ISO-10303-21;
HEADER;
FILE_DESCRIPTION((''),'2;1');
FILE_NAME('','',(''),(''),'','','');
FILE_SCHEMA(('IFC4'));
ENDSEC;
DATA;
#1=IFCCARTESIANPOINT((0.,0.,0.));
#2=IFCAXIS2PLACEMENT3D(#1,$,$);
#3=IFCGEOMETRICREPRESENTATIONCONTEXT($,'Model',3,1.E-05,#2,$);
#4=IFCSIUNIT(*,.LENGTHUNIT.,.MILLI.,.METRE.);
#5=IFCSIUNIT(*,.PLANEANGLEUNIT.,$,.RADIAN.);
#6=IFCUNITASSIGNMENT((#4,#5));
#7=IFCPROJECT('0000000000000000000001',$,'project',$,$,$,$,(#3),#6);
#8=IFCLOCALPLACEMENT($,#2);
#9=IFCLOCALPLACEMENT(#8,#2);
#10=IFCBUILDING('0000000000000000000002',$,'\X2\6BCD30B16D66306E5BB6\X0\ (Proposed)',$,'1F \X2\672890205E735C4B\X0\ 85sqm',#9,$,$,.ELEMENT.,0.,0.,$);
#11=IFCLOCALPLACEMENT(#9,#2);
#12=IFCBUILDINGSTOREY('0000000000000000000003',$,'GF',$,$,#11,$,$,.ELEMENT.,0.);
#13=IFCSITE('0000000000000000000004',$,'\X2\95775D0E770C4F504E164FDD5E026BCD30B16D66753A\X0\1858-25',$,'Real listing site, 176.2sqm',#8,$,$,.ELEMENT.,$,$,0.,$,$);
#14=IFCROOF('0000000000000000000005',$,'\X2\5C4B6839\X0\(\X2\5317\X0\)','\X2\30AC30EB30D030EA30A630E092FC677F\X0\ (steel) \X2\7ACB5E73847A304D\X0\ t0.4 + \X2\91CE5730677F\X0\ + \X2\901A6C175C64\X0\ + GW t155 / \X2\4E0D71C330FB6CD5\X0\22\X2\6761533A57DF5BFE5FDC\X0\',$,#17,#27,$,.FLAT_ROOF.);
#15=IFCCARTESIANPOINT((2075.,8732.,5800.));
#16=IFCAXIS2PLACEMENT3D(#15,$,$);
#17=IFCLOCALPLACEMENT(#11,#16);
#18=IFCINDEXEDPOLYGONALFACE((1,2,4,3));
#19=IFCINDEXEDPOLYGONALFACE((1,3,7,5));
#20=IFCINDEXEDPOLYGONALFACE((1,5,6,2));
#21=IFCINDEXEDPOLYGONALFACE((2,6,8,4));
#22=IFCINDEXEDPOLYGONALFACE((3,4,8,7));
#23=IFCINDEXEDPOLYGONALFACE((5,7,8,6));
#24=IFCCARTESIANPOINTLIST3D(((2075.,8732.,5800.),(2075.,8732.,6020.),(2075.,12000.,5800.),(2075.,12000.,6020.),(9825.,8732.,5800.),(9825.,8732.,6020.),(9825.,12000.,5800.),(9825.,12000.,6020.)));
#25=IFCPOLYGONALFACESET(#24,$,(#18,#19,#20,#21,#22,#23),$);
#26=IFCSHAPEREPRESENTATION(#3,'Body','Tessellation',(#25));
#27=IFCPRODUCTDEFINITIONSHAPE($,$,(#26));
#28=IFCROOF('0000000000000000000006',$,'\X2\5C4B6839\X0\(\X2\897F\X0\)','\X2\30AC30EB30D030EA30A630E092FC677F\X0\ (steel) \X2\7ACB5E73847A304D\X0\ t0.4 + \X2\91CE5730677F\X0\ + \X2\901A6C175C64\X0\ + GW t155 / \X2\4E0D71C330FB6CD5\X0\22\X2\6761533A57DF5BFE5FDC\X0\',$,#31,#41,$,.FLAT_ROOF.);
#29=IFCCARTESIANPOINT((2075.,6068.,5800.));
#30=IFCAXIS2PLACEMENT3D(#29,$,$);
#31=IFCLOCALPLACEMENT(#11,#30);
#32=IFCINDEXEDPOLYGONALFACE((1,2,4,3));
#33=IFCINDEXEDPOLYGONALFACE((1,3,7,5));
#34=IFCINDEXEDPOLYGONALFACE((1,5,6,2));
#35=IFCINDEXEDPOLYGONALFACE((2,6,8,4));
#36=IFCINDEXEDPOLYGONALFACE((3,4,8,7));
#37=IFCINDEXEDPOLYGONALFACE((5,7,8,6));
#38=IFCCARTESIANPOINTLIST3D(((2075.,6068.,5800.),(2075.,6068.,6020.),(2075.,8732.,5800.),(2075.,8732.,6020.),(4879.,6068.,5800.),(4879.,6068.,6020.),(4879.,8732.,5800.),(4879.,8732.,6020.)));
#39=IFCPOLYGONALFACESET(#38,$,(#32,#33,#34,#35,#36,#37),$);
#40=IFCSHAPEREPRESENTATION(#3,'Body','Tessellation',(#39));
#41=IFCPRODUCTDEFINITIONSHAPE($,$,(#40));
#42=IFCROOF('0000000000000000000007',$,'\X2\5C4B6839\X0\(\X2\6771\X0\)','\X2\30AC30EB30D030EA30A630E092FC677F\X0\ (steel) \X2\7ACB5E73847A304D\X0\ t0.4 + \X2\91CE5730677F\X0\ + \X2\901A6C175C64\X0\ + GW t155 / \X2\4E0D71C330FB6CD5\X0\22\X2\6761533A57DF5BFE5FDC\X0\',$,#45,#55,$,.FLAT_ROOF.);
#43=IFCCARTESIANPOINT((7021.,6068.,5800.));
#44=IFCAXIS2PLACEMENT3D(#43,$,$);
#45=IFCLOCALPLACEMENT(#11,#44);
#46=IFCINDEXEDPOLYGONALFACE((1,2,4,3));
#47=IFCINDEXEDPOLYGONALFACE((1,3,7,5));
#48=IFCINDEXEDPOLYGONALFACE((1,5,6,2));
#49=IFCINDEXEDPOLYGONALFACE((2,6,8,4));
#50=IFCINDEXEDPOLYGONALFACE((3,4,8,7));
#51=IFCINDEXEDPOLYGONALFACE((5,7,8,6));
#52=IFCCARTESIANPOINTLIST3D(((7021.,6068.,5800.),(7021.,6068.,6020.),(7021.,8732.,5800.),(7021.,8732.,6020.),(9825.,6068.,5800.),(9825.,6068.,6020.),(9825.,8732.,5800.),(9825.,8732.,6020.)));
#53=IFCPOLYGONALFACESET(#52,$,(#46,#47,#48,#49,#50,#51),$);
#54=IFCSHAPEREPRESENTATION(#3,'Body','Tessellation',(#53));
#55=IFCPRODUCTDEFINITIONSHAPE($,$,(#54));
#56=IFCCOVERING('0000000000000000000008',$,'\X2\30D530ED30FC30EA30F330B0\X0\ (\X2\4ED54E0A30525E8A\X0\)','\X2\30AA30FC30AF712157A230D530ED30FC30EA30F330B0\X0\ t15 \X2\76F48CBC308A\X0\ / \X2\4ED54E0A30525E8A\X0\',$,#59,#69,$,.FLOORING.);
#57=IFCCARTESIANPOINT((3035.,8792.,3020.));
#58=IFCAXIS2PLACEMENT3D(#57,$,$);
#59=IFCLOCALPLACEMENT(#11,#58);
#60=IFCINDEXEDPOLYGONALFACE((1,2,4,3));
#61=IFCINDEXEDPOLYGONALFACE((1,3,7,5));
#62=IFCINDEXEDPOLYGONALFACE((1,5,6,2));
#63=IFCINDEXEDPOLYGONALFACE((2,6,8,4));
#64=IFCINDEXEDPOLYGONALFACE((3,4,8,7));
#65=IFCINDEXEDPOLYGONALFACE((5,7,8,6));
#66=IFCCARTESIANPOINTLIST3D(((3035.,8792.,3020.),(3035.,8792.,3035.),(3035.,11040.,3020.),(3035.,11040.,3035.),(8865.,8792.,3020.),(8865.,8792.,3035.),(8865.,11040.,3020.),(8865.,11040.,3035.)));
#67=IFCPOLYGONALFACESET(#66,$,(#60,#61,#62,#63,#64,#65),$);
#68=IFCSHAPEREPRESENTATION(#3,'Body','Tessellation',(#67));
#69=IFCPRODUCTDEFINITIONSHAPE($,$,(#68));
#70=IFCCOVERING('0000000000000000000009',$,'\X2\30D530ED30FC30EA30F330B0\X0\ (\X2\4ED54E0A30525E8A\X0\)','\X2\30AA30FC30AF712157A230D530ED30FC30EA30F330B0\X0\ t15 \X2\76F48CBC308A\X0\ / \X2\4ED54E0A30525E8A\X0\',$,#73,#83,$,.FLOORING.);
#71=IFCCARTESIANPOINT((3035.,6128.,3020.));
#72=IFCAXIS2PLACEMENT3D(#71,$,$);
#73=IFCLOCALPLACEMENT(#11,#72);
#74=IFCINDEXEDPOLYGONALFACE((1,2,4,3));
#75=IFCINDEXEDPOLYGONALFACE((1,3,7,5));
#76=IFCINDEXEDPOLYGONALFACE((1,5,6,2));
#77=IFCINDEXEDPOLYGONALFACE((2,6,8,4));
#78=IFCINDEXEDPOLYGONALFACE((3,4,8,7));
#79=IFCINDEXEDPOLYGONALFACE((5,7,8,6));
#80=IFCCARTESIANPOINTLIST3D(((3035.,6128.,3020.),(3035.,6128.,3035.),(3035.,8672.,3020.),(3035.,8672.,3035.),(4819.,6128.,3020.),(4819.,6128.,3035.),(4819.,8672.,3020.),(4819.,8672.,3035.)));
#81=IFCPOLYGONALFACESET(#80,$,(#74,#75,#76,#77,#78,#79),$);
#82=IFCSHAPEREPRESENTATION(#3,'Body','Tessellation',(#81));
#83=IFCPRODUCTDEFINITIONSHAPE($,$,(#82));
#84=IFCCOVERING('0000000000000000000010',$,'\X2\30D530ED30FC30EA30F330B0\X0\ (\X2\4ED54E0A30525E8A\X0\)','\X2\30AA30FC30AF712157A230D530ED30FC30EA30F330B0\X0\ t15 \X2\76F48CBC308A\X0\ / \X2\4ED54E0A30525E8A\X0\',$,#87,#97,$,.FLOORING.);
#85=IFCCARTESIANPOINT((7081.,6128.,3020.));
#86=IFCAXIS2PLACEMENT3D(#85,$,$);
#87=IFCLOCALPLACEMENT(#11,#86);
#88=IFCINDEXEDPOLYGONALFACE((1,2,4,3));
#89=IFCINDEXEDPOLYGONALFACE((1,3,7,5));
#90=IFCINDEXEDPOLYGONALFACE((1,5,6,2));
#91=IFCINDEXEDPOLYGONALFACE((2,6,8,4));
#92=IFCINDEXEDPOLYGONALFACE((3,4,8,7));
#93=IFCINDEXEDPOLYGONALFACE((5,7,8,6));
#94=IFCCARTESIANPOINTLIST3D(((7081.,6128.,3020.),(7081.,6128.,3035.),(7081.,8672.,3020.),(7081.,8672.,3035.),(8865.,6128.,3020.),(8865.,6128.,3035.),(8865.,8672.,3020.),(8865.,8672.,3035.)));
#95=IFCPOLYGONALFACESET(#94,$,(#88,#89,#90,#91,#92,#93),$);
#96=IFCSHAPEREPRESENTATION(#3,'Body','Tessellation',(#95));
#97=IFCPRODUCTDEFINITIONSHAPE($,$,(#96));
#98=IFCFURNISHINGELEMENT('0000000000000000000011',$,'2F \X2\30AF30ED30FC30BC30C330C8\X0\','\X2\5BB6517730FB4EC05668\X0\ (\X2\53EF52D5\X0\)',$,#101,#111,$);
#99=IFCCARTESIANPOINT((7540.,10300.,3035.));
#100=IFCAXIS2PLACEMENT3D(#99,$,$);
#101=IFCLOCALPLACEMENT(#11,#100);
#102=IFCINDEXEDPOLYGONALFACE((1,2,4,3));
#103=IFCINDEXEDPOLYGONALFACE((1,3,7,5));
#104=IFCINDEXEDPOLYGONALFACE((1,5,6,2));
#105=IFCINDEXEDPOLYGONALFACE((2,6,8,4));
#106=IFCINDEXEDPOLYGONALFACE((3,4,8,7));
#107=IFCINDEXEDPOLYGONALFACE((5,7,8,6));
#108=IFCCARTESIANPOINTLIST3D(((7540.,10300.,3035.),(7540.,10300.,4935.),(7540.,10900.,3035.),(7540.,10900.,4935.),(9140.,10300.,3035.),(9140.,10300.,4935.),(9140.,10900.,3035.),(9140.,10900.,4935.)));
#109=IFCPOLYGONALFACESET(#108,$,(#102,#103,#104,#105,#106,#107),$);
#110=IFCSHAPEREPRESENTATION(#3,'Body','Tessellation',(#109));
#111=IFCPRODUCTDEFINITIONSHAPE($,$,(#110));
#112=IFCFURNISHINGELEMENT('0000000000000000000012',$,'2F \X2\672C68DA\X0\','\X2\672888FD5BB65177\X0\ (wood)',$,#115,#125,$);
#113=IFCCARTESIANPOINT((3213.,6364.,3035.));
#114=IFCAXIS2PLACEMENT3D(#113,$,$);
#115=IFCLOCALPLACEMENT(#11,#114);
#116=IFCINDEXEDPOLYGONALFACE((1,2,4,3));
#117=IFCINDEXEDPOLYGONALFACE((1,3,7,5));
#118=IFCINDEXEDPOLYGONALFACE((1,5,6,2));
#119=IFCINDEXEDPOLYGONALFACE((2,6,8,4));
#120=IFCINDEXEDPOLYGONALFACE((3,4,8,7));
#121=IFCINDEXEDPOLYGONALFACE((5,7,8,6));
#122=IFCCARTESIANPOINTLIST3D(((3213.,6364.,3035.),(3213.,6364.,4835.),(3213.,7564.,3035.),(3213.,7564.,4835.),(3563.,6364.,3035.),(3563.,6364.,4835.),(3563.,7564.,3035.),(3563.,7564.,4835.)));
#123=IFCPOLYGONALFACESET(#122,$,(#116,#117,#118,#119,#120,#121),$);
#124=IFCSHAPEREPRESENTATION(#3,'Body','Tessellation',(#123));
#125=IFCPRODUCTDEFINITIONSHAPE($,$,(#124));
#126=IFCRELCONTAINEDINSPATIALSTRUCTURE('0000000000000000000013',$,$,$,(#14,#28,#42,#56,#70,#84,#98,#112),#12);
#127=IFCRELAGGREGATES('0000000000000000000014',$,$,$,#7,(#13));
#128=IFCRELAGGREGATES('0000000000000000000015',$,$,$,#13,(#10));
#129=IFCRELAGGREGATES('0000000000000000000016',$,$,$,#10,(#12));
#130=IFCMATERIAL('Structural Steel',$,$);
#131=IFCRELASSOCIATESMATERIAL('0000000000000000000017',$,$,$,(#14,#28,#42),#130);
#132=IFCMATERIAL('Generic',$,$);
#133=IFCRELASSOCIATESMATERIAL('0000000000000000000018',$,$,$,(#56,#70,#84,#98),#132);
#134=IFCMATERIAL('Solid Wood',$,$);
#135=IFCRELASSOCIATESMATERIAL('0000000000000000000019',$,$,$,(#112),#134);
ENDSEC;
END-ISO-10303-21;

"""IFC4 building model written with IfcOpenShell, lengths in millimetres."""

from ifc_helpers import new_model, si_unit, frame, frame_2d, origin, place, context, project, spatial, rectangle, extrude, material, element, save


model = new_model("IFC4")

# Units and contexts
model_context = context("Model", 3, precision=1e-05, world=origin())
ifc_project = project(units=[si_unit("LENGTHUNIT", "METRE", prefix="MILLI"), si_unit("PLANEANGLEUNIT", "RADIAN")], contexts=[model_context])

# Site, building, storey
site_placement = place(None, origin())
site = spatial("IfcSite", under=ifc_project, at=site_placement, Name="長崎県佐世保市母ケ浦町1858-25", ObjectType="Real listing site, 176.2sqm", CompositionType="ELEMENT", RefElevation=0.0)
building_placement = place(site_placement, origin())
building = spatial("IfcBuilding", under=site, at=building_placement, Name="母ケ浦の家 (Proposed)", ObjectType="1F 木造平屋 85sqm", CompositionType="ELEMENT", ElevationOfRefHeight=0.0, ElevationOfTerrain=0.0)
storey_placement = place(building_placement, origin())
storey = spatial("IfcBuildingStorey", under=building, at=storey_placement, Name="GF", CompositionType="ELEMENT", Elevation=0.0)

# Shared definitions
ifc_material_1 = material(Name="Solid Wood")

# Shared definitions
ifc_material_2 = material(Name="Generic")

# Roofs
ifc_material_3 = material(Name="Structural Steel")
for number, where, name in (
    (1, (2075.0, 8732.0, 5800.0), "屋根(北)"),
):
    element("IfcRoof", number, at=place(storey_placement, frame(where)), inside=storey, material=ifc_material_3, Name=name, Description="ガルバリウム鋼板 (steel) 立平葺き t0.4 + 野地板 + 通気層 + GW t155 / 不燃・法22条区域対応", PredefinedType="FLAT_ROOF", context=model_context, shape_type="SweptSolid", body=[
        extrude(rectangle(XDim=7750.0, YDim=3268.0, at=frame_2d((3875.0, 1634.0))), frame((2075.0, 8732.0, 5800.0)), (0.0, 0.0, 1.0), 220.0),
    ])
roof_1_placement = place(storey_placement, frame((2075.0, 6068.0, 5800.0)))
element("IfcRoof", 2, at=roof_1_placement, inside=storey, material=ifc_material_3, Name="屋根(西)", Description="ガルバリウム鋼板 (steel) 立平葺き t0.4 + 野地板 + 通気層 + GW t155 / 不燃・法22条区域対応", PredefinedType="FLAT_ROOF", context=model_context, shape_type="SweptSolid", body=[
    extrude(rectangle(XDim=2804.0, YDim=2664.0, at=frame_2d((1402.0, 1332.0))), frame((2075.0, 6068.0, 5800.0)), (0.0, 0.0, 1.0), 220.0),
])
roof_2_placement = place(storey_placement, frame((7021.0, 6068.0, 5800.0)))
element("IfcRoof", 3, at=roof_2_placement, inside=storey, material=ifc_material_3, Name="屋根(東)", Description="ガルバリウム鋼板 (steel) 立平葺き t0.4 + 野地板 + 通気層 + GW t155 / 不燃・法22条区域対応", PredefinedType="FLAT_ROOF", context=model_context, shape_type="SweptSolid", body=[
    extrude(rectangle(XDim=2804.0, YDim=2664.0, at=frame_2d((1402.0, 1332.0))), frame((7021.0, 6068.0, 5800.0)), (0.0, 0.0, 1.0), 220.0),
])

# Coverings
covering_1_placement = place(storey_placement, frame((3035.0, 8792.0, 3020.0)))
element("IfcCovering", 4, at=covering_1_placement, inside=storey, material=ifc_material_2, Name="フローリング (仕上げ床)", Description="オーク無垢フローリング t15 直貼り / 仕上げ床", PredefinedType="FLOORING", context=model_context, shape_type="SweptSolid", body=[
    extrude(rectangle(XDim=5830.0, YDim=2248.0, at=frame_2d((2915.0, 1124.0))), frame((3035.0, 8792.0, 3020.0)), (0.0, 0.0, 1.0), 15.0),
])
covering_2_placement = place(storey_placement, frame((3035.0, 6128.0, 3020.0)))
element("IfcCovering", 5, at=covering_2_placement, inside=storey, material=ifc_material_2, Name="フローリング (仕上げ床)", Description="オーク無垢フローリング t15 直貼り / 仕上げ床", PredefinedType="FLOORING", context=model_context, shape_type="SweptSolid", body=[
    extrude(rectangle(XDim=1784.0, YDim=2544.0, at=frame_2d((892.0, 1272.0))), frame((3035.0, 6128.0, 3020.0)), (0.0, 0.0, 1.0), 15.0),
])
covering_3_placement = place(storey_placement, frame((7081.0, 6128.0, 3020.0)))
element("IfcCovering", 6, at=covering_3_placement, inside=storey, material=ifc_material_2, Name="フローリング (仕上げ床)", Description="オーク無垢フローリング t15 直貼り / 仕上げ床", PredefinedType="FLOORING", context=model_context, shape_type="SweptSolid", body=[
    extrude(rectangle(XDim=1784.0, YDim=2544.0, at=frame_2d((892.0, 1272.0))), frame((7081.0, 6128.0, 3020.0)), (0.0, 0.0, 1.0), 15.0),
])

# Furnishing elements
furnishing_1_placement = place(storey_placement, frame((7540.0, 10300.0, 3035.0)))
element("IfcFurnishingElement", 7, at=furnishing_1_placement, inside=storey, material=ifc_material_2, Name="2F クローゼット", Description="家具・什器 (可動)", context=model_context, shape_type="SweptSolid", body=[
    extrude(rectangle(XDim=1600.0, YDim=600.0, at=frame_2d((800.0, 300.0))), frame((7540.0, 10300.0, 3035.0)), (0.0, 0.0, 1.0), 1900.0),
])
furnishing_2_placement = place(storey_placement, frame((3213.0, 6364.0, 3035.0)))
element("IfcFurnishingElement", 8, at=furnishing_2_placement, inside=storey, material=ifc_material_1, Name="2F 本棚", Description="木製家具 (wood)", context=model_context, shape_type="SweptSolid", body=[
    extrude(rectangle(XDim=350.0, YDim=1200.0, at=frame_2d((175.0, 600.0))), frame((3213.0, 6364.0, 3035.0)), (0.0, 0.0, 1.0), 1800.0),
])

save(model, "model.ifc")
